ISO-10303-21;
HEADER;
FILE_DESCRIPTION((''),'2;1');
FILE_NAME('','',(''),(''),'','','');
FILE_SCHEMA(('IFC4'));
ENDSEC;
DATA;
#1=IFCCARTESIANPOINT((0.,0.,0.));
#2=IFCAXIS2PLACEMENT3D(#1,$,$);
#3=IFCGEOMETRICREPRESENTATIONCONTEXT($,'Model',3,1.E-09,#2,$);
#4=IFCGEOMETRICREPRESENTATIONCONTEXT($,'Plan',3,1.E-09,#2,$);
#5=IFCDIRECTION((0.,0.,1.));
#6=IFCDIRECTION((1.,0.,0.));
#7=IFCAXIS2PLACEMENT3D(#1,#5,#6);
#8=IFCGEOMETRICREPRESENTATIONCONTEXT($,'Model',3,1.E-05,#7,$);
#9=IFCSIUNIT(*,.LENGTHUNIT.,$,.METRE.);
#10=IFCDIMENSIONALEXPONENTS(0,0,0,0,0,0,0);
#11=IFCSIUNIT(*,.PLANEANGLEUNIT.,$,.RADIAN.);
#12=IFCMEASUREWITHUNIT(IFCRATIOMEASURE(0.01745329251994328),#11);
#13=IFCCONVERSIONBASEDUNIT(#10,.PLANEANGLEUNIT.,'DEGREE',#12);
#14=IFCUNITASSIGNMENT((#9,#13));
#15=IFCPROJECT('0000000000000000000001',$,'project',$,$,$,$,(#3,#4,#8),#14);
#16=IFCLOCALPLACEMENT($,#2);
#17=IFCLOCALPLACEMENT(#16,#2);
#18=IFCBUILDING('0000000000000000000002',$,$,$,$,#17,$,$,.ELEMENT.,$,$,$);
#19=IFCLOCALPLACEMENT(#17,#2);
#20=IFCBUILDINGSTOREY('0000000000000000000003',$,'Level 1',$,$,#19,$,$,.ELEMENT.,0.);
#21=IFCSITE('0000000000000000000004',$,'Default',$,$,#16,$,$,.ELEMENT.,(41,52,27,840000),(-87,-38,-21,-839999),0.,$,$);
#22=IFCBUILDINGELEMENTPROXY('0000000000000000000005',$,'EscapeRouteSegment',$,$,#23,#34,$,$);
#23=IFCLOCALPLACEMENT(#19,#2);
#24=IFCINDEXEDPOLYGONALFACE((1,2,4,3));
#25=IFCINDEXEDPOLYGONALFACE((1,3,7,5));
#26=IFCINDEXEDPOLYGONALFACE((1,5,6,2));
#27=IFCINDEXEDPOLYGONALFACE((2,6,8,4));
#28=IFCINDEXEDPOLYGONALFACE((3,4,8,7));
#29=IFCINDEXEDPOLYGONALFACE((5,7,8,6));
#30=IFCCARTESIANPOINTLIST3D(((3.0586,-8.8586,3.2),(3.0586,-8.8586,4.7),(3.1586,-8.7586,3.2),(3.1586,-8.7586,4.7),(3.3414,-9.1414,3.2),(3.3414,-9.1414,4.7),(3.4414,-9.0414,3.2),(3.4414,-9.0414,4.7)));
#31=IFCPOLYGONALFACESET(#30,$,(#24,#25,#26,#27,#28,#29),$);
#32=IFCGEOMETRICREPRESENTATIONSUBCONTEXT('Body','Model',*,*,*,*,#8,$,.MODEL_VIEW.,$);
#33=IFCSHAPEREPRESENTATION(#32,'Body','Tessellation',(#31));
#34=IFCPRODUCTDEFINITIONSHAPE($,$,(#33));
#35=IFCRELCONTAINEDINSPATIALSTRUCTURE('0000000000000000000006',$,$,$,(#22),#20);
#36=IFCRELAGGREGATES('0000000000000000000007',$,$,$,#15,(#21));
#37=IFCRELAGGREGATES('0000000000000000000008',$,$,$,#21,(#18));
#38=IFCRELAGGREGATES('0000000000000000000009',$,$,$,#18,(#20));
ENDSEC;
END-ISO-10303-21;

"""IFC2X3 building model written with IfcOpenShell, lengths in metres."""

from ifc_helpers import new_model, entity, si_unit, converted_unit, frame, origin, origin_with_axes, place, context, subcontext, project, spatial, polyline, outline, extrude, element, save


model = new_model("IFC2X3")

# Units and contexts
model_context_1 = context("Model", 3, precision=1e-09, world=origin())
plan_context = context("Plan", 3, precision=1e-09, world=origin())
model_context_2 = context("Model", 3, precision=1e-05, world=origin_with_axes())
body_context = subcontext(model_context_2, "Body", "Model", "MODEL_VIEW")
ifc_project = project(units=[si_unit("LENGTHUNIT", "METRE"), converted_unit("PLANEANGLEUNIT", "DEGREE", entity("IfcRatioMeasure", 0.01745329251994328), si_unit("PLANEANGLEUNIT", "RADIAN"), dimensions=[0, 0, 0, 0, 0, 0, 0])], contexts=[model_context_1, plan_context, model_context_2])

# Site, building, storey
site_placement = place(None, origin())
site = spatial("IfcSite", under=ifc_project, at=site_placement, Name="Default", CompositionType="ELEMENT", RefLatitude=(41, 52, 27, 840000), RefLongitude=(-87, -38, -21, -839999), RefElevation=0.0)
building_placement = place(site_placement, origin())
building = spatial("IfcBuilding", under=site, at=building_placement, CompositionType="ELEMENT")
storey_placement = place(building_placement, origin())
storey = spatial("IfcBuildingStorey", under=building, at=storey_placement, Name="Level 1", CompositionType="ELEMENT", Elevation=0.0)

# Building element proxy
proxy_1_placement = place(storey_placement, frame((3.3, -8.9, 3.2), z_axis=(0.0, 0.0, 1.0), x_axis=(-0.707105, -0.707108, 0.0)))
element("IfcBuildingElementProxy", 1, at=proxy_1_placement, inside=storey, Name="EscapeRouteSegment", context=body_context, shape_type="SweptSolid", body=[
    extrude(outline(polyline([(0.0, -0.2), (0.0, 0.2), (0.1414, 0.2), (0.1414, -0.2), (0.0, -0.2)])), origin_with_axes(), (0.0, 0.0, 1.0), 1.5),
])

save(model, "model.ifc")
